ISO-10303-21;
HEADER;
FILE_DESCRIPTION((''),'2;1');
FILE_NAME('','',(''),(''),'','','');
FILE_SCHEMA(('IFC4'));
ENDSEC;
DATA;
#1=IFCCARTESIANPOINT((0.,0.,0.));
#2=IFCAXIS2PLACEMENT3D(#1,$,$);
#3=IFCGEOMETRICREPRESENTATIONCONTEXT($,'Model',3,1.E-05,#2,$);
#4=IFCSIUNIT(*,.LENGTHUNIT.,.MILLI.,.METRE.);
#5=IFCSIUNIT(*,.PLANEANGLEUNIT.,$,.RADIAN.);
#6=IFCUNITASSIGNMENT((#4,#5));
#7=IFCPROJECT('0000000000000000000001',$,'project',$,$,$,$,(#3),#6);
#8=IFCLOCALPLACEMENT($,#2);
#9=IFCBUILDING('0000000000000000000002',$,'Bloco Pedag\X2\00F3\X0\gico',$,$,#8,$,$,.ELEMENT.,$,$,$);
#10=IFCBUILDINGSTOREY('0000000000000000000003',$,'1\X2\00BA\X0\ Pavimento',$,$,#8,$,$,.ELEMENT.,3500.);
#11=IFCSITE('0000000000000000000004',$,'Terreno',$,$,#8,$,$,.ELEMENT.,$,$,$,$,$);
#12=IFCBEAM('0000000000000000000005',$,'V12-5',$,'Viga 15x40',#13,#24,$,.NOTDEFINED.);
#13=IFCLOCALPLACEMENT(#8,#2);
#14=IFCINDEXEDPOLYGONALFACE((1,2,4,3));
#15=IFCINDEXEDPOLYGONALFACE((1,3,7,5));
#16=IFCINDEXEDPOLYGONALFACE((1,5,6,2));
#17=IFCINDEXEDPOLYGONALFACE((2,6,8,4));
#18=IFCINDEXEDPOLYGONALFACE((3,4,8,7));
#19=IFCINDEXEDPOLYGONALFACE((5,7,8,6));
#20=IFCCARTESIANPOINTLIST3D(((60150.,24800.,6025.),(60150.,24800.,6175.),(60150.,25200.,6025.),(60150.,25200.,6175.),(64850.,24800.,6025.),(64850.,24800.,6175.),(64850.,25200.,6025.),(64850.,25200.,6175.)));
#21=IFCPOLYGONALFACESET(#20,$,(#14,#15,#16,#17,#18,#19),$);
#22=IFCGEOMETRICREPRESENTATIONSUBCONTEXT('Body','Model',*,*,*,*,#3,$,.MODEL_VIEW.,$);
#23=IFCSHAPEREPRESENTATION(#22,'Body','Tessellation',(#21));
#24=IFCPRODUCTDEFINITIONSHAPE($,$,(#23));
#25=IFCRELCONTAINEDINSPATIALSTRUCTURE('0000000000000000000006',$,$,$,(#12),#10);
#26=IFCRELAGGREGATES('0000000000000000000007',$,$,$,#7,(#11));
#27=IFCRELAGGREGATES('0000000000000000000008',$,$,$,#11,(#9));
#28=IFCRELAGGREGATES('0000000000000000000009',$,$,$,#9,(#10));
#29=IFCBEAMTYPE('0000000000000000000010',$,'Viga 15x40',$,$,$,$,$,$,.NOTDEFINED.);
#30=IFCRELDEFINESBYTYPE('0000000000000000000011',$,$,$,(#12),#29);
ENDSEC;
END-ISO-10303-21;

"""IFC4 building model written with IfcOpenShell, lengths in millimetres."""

from ifc_helpers import new_model, si_unit, frame, origin, origin_2d, place, context, subcontext, project, spatial, rectangle, extrude, type_object, element, save


model = new_model("IFC4")

# Units and contexts
model_context = context("Model", 3, precision=1e-05, world=origin())
body_context = subcontext(model_context, "Body", "Model", "MODEL_VIEW")
ifc_project = project(units=[si_unit("LENGTHUNIT", "METRE", prefix="MILLI"), si_unit("PLANEANGLEUNIT", "RADIAN")], contexts=[model_context])

# Site, building, storey
placement = place(None, origin())
site = spatial("IfcSite", under=ifc_project, at=placement, Name="Terreno", CompositionType="ELEMENT")
building = spatial("IfcBuilding", under=site, at=placement, Name="Bloco Pedagógico", CompositionType="ELEMENT")
storey = spatial("IfcBuildingStorey", under=building, at=placement, Name="1º Pavimento", CompositionType="ELEMENT", Elevation=3500.0)

# Beam
beam_type = type_object("IfcBeamType", Name="Viga 15x40", PredefinedType="NOTDEFINED")
for number, where, z_axis, x_axis, name in (
    (1, (60150.0, 25000.0, 6100.0), (1.0, 0.0, 0.0), (0.0, 1.0, 0.0), "V12-5"),
):
    element("IfcBeam", number, at=place(None, frame(where, z_axis=z_axis, x_axis=x_axis)), inside=storey, type_object=beam_type, Name=name, ObjectType="Viga 15x40", PredefinedType="NOTDEFINED", context=body_context, shape_type="SweptSolid", body=[
        extrude(rectangle(XDim=400.0, YDim=150.0, at=origin_2d()), None, (0.0, 0.0, 1.0), 4700.0),
    ])

save(model, "model.ifc")
